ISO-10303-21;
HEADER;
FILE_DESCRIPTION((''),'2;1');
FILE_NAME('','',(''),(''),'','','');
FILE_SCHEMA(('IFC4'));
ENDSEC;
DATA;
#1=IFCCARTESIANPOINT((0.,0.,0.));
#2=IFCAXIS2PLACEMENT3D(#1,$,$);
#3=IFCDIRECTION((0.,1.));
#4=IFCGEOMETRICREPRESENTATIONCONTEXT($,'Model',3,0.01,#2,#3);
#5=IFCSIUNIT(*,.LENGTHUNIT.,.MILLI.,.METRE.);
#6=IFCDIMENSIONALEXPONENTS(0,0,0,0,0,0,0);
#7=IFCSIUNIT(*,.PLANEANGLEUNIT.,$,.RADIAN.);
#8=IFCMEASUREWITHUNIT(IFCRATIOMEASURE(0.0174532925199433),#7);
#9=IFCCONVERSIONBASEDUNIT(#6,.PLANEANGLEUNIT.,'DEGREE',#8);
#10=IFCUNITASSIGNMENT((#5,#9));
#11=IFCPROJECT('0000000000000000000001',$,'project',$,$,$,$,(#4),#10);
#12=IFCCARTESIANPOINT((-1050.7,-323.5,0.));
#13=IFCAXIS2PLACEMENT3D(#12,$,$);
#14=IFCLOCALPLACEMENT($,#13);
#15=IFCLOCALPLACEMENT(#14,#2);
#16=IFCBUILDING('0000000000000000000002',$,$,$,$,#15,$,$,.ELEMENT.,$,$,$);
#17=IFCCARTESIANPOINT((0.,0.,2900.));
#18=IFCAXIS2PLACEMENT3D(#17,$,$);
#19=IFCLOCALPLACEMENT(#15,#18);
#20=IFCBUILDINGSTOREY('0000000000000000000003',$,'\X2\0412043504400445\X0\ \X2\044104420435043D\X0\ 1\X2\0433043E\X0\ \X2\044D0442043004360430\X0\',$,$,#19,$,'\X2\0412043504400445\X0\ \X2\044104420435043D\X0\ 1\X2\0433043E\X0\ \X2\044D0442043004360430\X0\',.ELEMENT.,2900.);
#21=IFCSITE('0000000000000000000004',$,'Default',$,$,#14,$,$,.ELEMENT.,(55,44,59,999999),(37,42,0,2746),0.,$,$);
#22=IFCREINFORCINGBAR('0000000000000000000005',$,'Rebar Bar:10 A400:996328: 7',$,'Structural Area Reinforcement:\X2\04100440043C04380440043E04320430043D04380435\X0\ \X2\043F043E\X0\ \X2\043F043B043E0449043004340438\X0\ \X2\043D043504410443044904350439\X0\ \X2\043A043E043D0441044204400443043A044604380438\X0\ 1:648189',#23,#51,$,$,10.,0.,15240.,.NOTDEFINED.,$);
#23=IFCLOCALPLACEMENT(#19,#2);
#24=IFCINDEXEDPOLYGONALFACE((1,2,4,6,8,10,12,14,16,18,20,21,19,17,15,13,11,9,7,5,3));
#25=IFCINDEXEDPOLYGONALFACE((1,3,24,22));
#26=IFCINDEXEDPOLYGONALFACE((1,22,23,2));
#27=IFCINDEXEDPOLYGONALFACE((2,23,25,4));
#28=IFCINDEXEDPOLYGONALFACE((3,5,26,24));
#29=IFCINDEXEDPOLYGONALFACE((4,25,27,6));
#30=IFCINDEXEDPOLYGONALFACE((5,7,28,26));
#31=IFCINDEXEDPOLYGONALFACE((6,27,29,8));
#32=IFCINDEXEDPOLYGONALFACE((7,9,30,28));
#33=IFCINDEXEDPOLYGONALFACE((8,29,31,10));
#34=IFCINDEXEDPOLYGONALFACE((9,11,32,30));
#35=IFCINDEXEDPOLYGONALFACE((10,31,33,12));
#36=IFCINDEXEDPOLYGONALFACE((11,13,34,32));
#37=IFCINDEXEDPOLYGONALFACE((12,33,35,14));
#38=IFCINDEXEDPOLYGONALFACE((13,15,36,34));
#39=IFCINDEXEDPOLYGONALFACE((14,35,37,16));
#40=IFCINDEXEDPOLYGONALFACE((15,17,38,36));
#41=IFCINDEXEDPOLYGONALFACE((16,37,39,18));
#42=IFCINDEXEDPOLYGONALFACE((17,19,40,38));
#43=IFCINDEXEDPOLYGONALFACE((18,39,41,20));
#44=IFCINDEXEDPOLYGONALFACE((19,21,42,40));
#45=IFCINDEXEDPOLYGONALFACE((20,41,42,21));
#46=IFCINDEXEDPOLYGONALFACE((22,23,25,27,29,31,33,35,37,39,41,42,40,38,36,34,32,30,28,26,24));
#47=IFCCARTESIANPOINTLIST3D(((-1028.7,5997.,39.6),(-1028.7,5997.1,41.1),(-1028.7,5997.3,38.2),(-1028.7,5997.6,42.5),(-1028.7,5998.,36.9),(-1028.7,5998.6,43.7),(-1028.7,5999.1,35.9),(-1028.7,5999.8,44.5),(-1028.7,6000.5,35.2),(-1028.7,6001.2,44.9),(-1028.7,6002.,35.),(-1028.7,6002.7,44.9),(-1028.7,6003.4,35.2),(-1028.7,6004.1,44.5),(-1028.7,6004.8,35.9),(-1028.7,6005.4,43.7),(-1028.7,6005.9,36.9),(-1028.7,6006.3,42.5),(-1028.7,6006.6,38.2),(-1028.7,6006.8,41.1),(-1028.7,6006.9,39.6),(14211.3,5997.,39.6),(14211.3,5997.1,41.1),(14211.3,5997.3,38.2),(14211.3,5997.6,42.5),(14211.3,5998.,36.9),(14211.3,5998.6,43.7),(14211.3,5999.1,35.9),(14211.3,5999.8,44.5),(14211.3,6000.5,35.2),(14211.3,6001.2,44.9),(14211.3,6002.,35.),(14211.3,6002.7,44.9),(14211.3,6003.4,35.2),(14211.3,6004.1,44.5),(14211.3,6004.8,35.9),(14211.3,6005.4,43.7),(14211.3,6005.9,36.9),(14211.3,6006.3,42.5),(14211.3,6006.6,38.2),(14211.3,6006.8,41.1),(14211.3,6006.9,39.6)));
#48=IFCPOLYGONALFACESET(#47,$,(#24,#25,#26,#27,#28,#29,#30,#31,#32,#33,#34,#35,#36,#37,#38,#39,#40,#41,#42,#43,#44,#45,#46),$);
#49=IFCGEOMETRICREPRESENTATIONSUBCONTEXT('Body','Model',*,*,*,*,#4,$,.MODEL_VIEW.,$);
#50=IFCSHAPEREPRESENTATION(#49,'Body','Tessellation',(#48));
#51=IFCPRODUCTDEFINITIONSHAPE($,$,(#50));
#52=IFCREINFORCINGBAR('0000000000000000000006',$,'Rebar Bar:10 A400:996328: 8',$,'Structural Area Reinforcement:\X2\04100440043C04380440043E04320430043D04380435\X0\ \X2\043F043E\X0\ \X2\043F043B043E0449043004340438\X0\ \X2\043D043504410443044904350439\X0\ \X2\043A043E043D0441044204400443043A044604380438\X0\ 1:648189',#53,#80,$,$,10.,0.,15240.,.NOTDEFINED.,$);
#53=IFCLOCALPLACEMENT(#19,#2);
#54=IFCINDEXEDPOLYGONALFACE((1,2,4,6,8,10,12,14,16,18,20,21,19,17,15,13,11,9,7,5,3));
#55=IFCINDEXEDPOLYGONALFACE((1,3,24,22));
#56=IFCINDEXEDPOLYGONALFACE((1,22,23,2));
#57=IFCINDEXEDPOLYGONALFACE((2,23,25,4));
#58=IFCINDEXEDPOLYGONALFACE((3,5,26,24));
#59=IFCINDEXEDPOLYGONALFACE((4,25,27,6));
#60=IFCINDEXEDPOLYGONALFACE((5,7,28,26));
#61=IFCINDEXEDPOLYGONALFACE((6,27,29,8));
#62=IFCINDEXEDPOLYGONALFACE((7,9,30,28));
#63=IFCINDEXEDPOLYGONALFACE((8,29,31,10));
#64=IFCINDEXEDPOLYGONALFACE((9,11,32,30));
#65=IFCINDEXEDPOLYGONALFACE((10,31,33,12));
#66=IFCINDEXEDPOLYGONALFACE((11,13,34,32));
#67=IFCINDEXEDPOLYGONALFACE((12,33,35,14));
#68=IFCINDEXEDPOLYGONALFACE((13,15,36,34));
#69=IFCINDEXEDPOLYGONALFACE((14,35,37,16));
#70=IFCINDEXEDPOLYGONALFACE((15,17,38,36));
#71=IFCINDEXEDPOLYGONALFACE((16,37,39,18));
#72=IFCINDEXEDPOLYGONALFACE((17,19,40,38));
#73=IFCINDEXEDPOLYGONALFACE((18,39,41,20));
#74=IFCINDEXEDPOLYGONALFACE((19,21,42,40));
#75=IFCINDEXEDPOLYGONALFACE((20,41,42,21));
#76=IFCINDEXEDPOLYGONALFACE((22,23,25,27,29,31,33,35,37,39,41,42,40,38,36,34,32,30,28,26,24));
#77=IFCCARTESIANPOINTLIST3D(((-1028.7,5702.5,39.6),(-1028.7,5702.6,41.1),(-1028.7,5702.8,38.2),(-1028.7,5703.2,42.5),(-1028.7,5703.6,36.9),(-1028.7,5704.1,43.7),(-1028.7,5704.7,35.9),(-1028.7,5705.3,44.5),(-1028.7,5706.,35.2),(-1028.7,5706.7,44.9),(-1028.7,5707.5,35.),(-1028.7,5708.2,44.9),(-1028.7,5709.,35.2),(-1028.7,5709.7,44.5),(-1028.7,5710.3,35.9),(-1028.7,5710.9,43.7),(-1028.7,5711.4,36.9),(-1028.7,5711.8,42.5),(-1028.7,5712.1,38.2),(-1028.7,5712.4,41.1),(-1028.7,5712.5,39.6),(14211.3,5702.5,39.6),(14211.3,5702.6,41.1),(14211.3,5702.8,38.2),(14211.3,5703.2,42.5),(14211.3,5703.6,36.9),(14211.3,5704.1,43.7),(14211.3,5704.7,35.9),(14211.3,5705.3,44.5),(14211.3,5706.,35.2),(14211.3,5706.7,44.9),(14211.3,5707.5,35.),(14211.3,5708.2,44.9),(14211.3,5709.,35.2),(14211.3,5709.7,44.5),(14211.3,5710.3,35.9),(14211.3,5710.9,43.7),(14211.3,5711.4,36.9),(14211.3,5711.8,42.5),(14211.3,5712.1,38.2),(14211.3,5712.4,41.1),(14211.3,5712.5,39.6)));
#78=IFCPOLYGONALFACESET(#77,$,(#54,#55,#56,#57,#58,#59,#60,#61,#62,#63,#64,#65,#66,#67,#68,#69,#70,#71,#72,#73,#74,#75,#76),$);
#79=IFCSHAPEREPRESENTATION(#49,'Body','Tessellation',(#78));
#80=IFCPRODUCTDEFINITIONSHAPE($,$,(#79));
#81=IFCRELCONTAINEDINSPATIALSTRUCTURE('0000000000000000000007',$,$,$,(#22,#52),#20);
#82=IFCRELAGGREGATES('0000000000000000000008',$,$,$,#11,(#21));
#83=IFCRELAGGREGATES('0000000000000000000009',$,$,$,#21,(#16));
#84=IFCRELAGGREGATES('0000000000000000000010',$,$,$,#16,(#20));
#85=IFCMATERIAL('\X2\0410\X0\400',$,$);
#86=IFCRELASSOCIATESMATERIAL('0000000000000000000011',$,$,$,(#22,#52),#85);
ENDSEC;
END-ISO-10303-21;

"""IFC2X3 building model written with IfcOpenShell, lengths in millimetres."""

from ifc_helpers import new_model, entity, si_unit, converted_unit, direction, frame, origin, place, context, subcontext, project, spatial, material, element, save


model = new_model("IFC2X3")

# Units and contexts
model_context = context("Model", 3, precision=0.01, world=origin(), true_north=direction((0.0, 1.0)))
body_context = subcontext(model_context, "Body", "Model", "MODEL_VIEW")
ifc_project = project(units=[si_unit("LENGTHUNIT", "METRE", prefix="MILLI"), converted_unit("PLANEANGLEUNIT", "DEGREE", entity("IfcRatioMeasure", 0.0174532925199433), si_unit("PLANEANGLEUNIT", "RADIAN"), dimensions=[0, 0, 0, 0, 0, 0, 0])], contexts=[model_context])

# Site, building, storey
site_placement = place(None, frame((-1050.7, -323.5, 0.0)))
site = spatial("IfcSite", under=ifc_project, at=site_placement, Name="Default", CompositionType="ELEMENT", RefLatitude=(55, 44, 59, 999999), RefLongitude=(37, 42, 0, 2746), RefElevation=0.0)
building_placement = place(site_placement, origin())
building = spatial("IfcBuilding", under=site, at=building_placement, CompositionType="ELEMENT")
storey_placement = place(building_placement, frame((0.0, 0.0, 2900.0)))
storey = spatial("IfcBuildingStorey", under=building, at=storey_placement, Name="Верх стен 1го этажа", LongName="Верх стен 1го этажа", CompositionType="ELEMENT", Elevation=2900.0)

# Reinforcing bars
ifc_material = material(Name="А400")
reinforcing_bar_1_placement = place(storey_placement, origin())
element("IfcReinforcingBar", 1, at=reinforcing_bar_1_placement, inside=storey, material=ifc_material, Name="Rebar Bar:10 A400:996328: 7", ObjectType="Structural Area Reinforcement:Армирование по площади несущей конструкции 1:648189", BarLength=15240.0, BarRole="NOTDEFINED", CrossSectionArea=0.0, NominalDiameter=10.0, context=body_context, shape_type="AdvancedSweptSolid", body=[
    entity("IfcSweptDiskSolid", entity("IfcCompositeCurve", [entity("IfcCompositeCurveSegment", "CONTINUOUS", True, entity("IfcPolyline", [entity("IfcCartesianPoint", [14211.3, 6002.0, 40.0]), entity("IfcCartesianPoint", [-1028.7, 6002.0, 40.0])]))], False), 5.0, None, 0.0, 1.0),
])
reinforcing_bar_2_placement = place(storey_placement, origin())
element("IfcReinforcingBar", 2, at=reinforcing_bar_2_placement, inside=storey, material=ifc_material, Name="Rebar Bar:10 A400:996328: 8", ObjectType="Structural Area Reinforcement:Армирование по площади несущей конструкции 1:648189", BarLength=15240.0, BarRole="NOTDEFINED", CrossSectionArea=0.0, NominalDiameter=10.0, context=body_context, shape_type="AdvancedSweptSolid", body=[
    entity("IfcSweptDiskSolid", entity("IfcCompositeCurve", [entity("IfcCompositeCurveSegment", "CONTINUOUS", True, entity("IfcPolyline", [entity("IfcCartesianPoint", [14211.3, 5707.5, 40.0]), entity("IfcCartesianPoint", [-1028.7, 5707.5, 40.0])]))], False), 5.0, None, 0.0, 1.0),
])

save(model, "model.ifc")
